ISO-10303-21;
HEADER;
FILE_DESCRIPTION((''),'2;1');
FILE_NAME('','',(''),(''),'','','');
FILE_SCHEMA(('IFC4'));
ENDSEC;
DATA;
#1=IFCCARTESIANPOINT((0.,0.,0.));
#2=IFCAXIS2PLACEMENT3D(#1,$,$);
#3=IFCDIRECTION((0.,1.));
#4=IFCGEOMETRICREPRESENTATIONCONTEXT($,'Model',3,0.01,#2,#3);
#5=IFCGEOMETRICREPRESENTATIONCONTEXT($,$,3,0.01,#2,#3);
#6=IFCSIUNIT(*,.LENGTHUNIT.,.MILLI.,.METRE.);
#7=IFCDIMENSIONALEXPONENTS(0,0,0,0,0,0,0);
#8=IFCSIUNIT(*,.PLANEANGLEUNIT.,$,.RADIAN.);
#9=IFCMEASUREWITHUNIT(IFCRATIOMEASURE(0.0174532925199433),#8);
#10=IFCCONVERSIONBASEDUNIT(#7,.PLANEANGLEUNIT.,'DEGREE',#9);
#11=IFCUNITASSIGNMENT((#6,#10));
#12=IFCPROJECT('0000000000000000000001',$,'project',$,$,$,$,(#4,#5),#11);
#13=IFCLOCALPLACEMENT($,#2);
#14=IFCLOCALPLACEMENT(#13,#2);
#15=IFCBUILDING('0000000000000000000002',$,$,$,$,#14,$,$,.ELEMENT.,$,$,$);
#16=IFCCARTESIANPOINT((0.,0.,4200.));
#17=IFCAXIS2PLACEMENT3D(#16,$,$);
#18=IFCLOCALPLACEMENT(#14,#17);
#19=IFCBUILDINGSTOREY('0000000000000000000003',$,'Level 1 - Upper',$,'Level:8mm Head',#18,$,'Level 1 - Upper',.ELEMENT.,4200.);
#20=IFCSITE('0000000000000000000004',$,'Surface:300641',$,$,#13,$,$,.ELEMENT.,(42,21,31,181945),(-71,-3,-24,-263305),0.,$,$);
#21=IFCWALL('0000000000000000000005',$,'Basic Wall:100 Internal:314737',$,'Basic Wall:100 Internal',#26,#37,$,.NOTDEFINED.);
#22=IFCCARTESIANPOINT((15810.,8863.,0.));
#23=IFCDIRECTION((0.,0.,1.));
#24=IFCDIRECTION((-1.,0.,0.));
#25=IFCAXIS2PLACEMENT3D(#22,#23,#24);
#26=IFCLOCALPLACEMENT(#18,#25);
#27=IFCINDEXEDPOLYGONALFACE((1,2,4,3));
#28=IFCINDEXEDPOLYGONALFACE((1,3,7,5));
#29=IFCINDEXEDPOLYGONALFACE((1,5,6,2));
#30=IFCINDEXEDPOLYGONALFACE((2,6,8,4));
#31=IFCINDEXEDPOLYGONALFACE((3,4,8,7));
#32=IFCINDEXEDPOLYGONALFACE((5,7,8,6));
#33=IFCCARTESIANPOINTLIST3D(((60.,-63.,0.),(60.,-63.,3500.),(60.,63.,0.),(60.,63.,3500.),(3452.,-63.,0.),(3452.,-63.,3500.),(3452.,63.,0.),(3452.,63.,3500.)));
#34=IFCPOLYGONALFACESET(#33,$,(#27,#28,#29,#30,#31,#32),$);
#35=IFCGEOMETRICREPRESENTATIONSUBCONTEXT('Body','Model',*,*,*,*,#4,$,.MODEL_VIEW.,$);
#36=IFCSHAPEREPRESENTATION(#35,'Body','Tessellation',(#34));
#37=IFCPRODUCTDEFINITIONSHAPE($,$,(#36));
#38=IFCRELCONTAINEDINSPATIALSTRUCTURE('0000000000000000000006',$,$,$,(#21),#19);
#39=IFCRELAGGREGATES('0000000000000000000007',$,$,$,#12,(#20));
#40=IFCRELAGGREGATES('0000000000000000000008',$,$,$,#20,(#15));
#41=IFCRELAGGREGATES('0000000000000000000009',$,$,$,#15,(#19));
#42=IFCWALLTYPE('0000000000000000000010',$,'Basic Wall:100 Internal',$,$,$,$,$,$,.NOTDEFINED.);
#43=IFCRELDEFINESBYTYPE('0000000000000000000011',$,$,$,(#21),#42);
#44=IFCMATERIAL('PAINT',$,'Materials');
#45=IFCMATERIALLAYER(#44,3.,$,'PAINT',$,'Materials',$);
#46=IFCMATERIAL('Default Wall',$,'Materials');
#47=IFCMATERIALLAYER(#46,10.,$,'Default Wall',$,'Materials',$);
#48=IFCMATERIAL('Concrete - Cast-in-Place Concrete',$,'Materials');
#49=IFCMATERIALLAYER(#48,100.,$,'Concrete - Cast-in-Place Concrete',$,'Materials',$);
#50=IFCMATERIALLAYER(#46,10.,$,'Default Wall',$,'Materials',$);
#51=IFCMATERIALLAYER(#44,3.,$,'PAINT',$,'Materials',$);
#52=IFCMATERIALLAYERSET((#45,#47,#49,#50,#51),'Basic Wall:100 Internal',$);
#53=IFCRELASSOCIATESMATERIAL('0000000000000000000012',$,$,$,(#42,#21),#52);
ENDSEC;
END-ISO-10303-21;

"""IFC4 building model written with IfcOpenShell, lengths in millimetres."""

from ifc_helpers import new_model, entity, si_unit, converted_unit, direction, frame, frame_2d, origin, place, context, subcontext, project, spatial, rectangle, extrude, clip, halfspace, material, layer, layer_set, layer_usage, type_object, element, save


model = new_model("IFC4")

# Units and contexts
model_context = context("Model", 3, precision=0.01, world=origin(), true_north=direction((0.0, 1.0)))
context_of_model = context(None, 3, precision=0.01, world=origin(), true_north=direction((0.0, 1.0)))
body_context = subcontext(model_context, "Body", "Model", "MODEL_VIEW")
ifc_project = project(units=[si_unit("LENGTHUNIT", "METRE", prefix="MILLI"), converted_unit("PLANEANGLEUNIT", "DEGREE", entity("IfcRatioMeasure", 0.0174532925199433), si_unit("PLANEANGLEUNIT", "RADIAN"), dimensions=[0, 0, 0, 0, 0, 0, 0])], contexts=[model_context, context_of_model])

# Site, building, storey
site_placement = place(None, origin())
site = spatial("IfcSite", under=ifc_project, at=site_placement, Name="Surface:300641", CompositionType="ELEMENT", RefLatitude=(42, 21, 31, 181945), RefLongitude=(-71, -3, -24, -263305), RefElevation=0.0)
building_placement = place(site_placement, origin())
building = spatial("IfcBuilding", under=site, at=building_placement, CompositionType="ELEMENT")
storey_placement = place(building_placement, frame((0.0, 0.0, 4200.0)))
storey = spatial("IfcBuildingStorey", under=building, at=storey_placement, Name="Level 1 - Upper", ObjectType="Level:8mm Head", LongName="Level 1 - Upper", CompositionType="ELEMENT", Elevation=4200.0)

# Shared definitions
ifc_material_1 = material(Name="PAINT", Category="Materials")
ifc_material_2 = material(Name="Concrete - Cast-in-Place Concrete", Category="Materials")
ifc_material_3 = material(Name="Default Wall", Category="Materials")

# Wall
ifc_layer_1 = layer(ifc_material_1, 3.0, Name="PAINT", Category="Materials")
ifc_layer_2 = layer(ifc_material_3, 10.0, Name="Default Wall", Category="Materials")
ifc_layer_3 = layer(ifc_material_2, 100.0, Name="Concrete - Cast-in-Place Concrete", Category="Materials")
ifc_layer_4 = layer(ifc_material_3, 10.0, Name="Default Wall", Category="Materials")
ifc_layer_5 = layer(ifc_material_1, 3.0, Name="PAINT", Category="Materials")
ifc_layer_set_1 = layer_set([ifc_layer_1, ifc_layer_2, ifc_layer_3, ifc_layer_4, ifc_layer_5], Name="Basic Wall:100 Internal")
ifc_layer_usage_1 = layer_usage(ifc_layer_set_1, "AXIS2", "NEGATIVE", 63.0)
wall_type_1 = type_object("IfcWallType", Name="Basic Wall:100 Internal", PredefinedType="NOTDEFINED", material=ifc_layer_set_1)
wall_1_placement = place(storey_placement, frame((15810.0, 8863.0, 0.0), z_axis=(0.0, 0.0, 1.0), x_axis=(-1.0, 0.0, 0.0)))
element("IfcWall", 1, at=wall_1_placement, inside=storey, type_object=wall_type_1, material=ifc_layer_usage_1, Name="Basic Wall:100 Internal:314737", ObjectType="Basic Wall:100 Internal", PredefinedType="NOTDEFINED", context=body_context, shape_type="Clipping", body=[
    clip(extrude(rectangle(XDim=3392.0, YDim=126.0, at=frame_2d((1756.0, 0.0), x_axis=(-1.0, 0.0))), origin(), (0.0, 0.0, 1.0), 3500.0), halfspace(origin(), True)),
])

save(model, "model.ifc")
